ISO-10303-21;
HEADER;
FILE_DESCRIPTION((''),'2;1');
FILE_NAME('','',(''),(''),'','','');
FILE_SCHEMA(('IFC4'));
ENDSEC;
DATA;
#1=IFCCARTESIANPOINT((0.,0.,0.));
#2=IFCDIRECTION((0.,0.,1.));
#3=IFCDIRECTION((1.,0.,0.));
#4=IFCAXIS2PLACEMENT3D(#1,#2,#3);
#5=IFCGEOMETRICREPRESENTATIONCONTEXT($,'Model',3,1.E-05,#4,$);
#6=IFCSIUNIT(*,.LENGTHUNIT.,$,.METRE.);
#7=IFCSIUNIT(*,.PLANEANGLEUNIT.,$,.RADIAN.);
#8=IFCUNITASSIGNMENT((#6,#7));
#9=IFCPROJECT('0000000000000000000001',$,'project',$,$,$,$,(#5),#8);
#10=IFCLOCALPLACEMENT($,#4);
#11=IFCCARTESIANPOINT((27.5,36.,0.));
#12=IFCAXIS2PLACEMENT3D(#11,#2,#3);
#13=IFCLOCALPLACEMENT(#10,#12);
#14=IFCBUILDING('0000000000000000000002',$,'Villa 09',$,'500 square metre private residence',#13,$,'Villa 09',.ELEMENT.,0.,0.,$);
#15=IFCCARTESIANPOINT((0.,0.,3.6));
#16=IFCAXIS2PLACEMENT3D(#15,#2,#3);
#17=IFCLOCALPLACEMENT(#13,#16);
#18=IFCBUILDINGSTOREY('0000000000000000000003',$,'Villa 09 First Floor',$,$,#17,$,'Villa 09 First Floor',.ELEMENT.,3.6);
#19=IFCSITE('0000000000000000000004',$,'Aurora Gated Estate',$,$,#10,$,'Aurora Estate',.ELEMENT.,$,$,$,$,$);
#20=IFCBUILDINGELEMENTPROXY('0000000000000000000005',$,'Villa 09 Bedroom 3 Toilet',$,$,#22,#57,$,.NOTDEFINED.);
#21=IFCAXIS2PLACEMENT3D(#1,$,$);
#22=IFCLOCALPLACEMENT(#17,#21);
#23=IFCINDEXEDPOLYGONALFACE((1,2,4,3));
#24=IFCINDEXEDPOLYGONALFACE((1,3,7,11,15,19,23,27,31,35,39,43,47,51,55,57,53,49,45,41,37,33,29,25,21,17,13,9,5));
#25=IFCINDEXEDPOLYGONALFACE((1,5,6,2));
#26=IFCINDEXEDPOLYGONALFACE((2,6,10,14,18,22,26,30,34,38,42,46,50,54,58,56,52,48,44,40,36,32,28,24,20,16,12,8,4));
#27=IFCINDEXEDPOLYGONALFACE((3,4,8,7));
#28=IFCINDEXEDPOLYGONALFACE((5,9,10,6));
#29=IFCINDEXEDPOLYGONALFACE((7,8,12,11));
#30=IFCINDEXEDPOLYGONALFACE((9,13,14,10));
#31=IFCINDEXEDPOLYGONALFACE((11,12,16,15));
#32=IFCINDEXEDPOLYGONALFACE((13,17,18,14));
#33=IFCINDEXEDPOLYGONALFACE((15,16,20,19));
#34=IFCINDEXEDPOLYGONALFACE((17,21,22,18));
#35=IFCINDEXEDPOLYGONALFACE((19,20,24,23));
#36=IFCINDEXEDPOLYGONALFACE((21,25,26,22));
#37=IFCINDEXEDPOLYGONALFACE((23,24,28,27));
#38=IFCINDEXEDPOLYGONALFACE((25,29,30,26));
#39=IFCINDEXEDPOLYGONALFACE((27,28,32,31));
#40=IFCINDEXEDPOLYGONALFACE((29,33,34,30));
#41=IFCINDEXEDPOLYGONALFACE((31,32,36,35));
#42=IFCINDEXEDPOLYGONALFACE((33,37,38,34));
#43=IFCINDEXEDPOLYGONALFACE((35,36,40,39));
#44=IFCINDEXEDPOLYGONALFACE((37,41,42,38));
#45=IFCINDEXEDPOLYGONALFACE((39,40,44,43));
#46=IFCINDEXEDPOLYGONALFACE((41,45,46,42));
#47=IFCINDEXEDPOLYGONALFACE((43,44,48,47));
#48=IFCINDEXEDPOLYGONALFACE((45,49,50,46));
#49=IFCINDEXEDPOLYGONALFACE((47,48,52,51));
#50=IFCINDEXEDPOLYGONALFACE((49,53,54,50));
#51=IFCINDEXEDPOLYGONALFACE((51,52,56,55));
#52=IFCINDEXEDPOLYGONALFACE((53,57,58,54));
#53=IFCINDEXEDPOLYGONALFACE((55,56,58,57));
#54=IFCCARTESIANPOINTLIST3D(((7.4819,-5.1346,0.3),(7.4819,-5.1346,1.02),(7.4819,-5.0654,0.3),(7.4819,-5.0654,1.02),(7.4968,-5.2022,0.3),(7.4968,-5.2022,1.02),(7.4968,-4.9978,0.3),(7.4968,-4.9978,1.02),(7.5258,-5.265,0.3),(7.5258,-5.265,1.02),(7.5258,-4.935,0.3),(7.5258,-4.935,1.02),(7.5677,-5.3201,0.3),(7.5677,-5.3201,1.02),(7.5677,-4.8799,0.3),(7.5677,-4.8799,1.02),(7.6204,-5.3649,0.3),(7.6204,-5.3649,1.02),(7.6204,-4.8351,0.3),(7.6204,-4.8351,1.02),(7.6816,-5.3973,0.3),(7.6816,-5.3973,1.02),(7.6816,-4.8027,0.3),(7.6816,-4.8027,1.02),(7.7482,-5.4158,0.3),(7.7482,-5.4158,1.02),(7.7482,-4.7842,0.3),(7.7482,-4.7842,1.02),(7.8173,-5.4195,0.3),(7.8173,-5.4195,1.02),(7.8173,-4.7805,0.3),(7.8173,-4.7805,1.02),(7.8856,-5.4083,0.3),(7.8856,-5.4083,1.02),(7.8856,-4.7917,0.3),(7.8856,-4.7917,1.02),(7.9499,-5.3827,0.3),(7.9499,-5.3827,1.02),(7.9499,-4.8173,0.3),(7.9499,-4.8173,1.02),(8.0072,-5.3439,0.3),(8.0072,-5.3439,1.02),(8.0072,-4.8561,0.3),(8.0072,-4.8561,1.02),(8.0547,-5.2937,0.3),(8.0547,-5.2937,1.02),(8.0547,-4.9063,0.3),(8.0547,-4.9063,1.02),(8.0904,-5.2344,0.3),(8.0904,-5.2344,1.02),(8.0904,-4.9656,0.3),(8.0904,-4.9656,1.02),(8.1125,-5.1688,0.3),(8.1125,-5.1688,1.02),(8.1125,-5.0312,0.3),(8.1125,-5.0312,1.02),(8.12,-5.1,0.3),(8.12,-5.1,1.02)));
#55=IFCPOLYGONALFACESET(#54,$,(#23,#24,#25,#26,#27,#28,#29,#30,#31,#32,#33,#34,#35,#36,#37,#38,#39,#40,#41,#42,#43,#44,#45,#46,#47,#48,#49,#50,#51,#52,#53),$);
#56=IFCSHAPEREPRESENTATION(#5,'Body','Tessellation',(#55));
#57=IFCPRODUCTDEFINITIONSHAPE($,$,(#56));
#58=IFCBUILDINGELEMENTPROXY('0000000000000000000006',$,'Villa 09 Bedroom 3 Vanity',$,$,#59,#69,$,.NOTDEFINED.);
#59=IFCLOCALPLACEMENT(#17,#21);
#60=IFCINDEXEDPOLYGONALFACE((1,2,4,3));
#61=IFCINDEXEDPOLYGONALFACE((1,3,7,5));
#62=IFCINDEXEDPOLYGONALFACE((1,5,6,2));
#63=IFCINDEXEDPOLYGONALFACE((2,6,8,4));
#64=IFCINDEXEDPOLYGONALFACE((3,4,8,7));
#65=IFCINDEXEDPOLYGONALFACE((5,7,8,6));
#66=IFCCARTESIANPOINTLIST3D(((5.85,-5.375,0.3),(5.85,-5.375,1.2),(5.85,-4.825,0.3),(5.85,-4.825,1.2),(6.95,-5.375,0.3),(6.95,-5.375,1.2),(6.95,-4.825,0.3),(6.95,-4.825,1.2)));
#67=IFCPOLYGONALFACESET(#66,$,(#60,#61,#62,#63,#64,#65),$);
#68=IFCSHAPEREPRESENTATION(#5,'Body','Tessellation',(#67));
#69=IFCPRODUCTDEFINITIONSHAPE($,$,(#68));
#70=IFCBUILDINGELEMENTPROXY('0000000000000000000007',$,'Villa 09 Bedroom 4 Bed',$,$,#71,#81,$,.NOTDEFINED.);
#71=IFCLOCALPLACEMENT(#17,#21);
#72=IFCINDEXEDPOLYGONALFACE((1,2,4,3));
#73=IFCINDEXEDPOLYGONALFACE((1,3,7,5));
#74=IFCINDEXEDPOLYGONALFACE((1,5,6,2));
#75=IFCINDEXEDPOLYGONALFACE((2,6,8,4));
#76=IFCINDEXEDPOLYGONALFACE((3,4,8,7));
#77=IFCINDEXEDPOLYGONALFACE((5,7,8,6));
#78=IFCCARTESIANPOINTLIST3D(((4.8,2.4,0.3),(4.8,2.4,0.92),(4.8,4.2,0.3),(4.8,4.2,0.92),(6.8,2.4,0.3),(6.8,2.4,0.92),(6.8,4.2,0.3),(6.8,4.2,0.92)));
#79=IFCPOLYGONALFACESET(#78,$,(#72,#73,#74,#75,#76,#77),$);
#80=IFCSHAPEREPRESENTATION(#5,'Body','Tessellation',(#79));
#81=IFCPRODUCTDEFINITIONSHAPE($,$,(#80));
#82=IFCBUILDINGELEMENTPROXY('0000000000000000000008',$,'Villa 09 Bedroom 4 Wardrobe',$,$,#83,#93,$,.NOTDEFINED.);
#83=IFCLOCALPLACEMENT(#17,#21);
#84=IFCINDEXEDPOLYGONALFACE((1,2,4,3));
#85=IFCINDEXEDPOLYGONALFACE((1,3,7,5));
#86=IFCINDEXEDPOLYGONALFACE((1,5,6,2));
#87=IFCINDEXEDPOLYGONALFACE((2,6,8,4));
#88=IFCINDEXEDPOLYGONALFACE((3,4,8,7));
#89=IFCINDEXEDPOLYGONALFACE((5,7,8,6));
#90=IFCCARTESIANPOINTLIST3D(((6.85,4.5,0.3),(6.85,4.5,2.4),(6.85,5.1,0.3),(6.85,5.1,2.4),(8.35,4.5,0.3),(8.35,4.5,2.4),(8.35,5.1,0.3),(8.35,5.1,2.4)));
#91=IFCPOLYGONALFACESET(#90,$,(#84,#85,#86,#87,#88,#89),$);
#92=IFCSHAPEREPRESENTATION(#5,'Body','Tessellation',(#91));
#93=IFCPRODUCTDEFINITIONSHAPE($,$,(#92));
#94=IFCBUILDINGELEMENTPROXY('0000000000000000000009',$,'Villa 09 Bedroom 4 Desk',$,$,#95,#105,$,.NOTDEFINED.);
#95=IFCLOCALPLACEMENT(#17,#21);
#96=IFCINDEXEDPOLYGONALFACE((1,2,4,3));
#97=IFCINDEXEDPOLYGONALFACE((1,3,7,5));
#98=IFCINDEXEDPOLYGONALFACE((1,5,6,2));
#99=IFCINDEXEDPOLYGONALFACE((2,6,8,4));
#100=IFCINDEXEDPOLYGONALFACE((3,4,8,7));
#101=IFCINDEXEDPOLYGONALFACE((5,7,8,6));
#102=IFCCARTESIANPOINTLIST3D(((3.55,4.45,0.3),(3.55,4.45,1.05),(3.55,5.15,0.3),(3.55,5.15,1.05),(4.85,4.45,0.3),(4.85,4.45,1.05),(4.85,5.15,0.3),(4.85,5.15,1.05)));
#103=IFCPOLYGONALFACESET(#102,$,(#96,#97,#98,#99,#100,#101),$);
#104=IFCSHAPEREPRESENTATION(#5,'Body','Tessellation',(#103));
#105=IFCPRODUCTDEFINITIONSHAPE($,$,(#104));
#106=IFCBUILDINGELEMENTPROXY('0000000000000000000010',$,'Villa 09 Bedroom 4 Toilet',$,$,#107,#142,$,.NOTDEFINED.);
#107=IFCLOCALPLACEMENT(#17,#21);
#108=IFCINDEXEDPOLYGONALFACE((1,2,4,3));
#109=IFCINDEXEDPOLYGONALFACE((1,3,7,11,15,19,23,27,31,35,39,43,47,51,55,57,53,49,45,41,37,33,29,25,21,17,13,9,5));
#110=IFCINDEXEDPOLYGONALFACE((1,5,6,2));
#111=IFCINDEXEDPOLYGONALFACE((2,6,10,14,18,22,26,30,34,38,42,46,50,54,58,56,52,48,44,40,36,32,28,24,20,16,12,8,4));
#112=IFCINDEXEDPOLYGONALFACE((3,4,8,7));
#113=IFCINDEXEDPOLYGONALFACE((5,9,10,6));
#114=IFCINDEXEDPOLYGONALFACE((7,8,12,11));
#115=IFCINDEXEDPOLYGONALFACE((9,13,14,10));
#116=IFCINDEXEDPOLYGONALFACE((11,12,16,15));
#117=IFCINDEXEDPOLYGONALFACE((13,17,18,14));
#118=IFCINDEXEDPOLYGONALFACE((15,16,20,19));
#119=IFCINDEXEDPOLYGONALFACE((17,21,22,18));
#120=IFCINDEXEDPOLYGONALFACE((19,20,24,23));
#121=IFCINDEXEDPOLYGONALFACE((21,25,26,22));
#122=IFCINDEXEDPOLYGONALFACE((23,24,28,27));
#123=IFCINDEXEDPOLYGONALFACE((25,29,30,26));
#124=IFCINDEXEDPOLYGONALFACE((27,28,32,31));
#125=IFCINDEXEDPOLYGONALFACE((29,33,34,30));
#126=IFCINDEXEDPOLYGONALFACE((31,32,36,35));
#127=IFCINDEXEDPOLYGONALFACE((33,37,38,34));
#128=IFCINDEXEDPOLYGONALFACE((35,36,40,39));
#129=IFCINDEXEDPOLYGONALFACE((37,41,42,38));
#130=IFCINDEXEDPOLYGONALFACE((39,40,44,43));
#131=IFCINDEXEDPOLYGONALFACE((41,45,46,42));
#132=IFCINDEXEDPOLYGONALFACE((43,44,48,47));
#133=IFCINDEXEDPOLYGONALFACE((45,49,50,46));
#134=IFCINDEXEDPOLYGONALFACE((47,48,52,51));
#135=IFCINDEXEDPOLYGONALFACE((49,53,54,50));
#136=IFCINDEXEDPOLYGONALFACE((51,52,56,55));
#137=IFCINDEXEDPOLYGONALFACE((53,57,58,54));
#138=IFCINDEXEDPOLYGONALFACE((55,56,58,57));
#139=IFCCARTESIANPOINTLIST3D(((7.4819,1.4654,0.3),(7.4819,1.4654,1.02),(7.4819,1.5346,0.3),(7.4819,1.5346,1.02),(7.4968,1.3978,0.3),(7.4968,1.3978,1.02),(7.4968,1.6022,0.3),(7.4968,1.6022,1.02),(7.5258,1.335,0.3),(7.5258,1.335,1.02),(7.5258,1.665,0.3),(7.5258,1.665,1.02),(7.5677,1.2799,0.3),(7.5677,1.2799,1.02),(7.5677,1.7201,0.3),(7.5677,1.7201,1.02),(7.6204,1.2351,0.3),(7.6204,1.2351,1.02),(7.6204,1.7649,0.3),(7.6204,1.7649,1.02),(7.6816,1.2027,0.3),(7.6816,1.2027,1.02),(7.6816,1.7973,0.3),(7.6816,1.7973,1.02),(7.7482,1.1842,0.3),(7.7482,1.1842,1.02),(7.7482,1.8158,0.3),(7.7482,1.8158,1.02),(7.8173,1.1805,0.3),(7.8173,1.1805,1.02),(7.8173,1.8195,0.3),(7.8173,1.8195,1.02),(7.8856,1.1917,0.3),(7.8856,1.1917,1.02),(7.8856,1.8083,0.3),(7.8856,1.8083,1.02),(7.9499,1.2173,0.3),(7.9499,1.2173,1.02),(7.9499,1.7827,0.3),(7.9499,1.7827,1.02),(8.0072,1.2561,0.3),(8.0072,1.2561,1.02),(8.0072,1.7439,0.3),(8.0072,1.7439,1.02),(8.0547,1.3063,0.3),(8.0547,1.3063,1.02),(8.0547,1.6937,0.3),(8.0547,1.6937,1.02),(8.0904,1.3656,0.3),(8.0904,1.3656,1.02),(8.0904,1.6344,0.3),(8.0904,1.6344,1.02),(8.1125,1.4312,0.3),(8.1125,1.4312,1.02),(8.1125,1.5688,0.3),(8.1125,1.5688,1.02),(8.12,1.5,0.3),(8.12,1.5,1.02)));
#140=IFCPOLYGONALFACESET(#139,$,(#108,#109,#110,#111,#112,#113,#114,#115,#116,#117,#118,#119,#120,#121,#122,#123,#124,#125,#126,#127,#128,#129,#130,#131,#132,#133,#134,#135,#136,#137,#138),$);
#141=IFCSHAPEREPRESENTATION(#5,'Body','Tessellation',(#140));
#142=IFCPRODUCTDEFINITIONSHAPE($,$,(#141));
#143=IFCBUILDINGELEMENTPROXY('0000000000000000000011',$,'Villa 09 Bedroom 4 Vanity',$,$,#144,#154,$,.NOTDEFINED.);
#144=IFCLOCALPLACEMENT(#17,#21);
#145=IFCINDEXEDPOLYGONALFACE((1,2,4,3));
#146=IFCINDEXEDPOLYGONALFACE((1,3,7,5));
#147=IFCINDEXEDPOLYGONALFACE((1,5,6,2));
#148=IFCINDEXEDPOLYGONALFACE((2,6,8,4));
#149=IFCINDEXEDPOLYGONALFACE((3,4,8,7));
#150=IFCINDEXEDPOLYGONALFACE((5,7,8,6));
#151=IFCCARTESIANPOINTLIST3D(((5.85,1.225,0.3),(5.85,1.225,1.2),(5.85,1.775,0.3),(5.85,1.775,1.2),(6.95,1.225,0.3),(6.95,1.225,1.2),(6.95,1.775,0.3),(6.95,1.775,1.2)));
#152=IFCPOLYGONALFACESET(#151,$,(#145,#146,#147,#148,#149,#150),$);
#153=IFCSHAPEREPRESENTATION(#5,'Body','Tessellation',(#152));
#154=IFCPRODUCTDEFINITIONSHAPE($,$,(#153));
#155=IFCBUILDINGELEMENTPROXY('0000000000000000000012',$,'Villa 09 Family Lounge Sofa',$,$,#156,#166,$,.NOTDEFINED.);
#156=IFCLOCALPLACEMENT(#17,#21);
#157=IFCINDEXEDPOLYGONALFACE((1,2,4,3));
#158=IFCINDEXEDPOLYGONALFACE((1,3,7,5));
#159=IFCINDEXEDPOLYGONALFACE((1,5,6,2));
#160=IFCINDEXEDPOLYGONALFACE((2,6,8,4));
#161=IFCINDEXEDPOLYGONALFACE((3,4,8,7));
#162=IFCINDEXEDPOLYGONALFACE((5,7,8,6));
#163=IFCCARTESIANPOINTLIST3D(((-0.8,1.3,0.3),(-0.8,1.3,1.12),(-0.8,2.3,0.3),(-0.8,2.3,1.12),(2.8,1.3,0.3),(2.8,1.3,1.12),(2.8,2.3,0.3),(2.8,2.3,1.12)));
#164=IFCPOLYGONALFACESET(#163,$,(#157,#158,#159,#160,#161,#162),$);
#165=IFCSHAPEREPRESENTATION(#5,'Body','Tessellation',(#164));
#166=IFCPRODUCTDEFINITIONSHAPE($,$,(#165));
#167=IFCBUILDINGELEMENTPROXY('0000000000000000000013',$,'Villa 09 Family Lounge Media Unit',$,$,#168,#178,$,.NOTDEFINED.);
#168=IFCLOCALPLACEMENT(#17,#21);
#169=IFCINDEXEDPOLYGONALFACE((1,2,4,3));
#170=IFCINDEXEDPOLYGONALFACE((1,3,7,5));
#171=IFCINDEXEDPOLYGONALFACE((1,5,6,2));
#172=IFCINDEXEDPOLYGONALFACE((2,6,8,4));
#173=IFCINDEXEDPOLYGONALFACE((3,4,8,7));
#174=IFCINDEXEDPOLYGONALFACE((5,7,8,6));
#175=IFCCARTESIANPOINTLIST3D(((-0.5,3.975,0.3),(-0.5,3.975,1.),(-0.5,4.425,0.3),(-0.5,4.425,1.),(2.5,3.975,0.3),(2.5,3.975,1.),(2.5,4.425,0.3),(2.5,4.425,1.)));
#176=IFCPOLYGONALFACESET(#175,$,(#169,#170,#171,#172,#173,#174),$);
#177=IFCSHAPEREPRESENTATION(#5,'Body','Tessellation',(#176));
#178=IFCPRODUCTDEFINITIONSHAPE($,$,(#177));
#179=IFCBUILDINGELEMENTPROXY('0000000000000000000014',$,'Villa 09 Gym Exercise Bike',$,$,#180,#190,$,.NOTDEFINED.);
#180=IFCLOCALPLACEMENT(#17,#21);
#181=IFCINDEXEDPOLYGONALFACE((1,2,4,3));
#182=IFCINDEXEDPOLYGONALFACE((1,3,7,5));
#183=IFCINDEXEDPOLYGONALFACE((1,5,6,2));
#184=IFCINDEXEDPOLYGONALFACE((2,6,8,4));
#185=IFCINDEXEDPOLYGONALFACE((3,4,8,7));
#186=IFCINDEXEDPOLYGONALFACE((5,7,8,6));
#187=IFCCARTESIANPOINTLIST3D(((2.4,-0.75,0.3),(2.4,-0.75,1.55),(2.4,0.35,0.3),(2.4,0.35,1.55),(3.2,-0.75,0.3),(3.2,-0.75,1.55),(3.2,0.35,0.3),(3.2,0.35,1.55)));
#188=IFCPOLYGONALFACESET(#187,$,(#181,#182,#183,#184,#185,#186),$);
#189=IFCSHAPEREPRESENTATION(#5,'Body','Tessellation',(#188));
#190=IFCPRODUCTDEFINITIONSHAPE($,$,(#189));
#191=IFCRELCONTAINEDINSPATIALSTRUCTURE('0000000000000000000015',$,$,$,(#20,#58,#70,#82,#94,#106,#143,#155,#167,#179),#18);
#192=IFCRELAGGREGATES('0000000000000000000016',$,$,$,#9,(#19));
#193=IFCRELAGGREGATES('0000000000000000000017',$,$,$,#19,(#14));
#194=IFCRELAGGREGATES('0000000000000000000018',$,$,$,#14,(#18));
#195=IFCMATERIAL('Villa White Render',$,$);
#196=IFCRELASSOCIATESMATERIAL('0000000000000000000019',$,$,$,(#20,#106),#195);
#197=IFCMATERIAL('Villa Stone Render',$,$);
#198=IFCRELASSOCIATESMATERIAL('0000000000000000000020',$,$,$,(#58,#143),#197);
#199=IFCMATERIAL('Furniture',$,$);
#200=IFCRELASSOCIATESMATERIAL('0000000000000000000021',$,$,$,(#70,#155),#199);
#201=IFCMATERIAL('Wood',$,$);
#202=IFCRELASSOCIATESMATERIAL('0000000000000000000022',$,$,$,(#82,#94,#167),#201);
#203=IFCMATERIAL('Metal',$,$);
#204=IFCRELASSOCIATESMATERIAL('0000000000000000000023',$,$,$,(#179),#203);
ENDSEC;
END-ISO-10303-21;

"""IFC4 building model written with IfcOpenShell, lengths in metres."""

from ifc_helpers import new_model, si_unit, frame, origin_with_axes, origin_2d_with_axis, place, context, project, spatial, rectangle, circle, extrude, material, element, save


model = new_model("IFC4")

# Units and contexts
model_context = context("Model", 3, precision=1e-05, world=origin_with_axes())
ifc_project = project(units=[si_unit("LENGTHUNIT", "METRE"), si_unit("PLANEANGLEUNIT", "RADIAN")], contexts=[model_context])

# Site, building, storey
site_placement = place(None, origin_with_axes())
site = spatial("IfcSite", under=ifc_project, at=site_placement, Name="Aurora Gated Estate", LongName="Aurora Estate", CompositionType="ELEMENT")
building_placement = place(site_placement, frame((27.5, 36.0, 0.0), z_axis=(0.0, 0.0, 1.0), x_axis=(1.0, 0.0, 0.0)))
building = spatial("IfcBuilding", under=site, at=building_placement, Name="Villa 09", ObjectType="500 square metre private residence", LongName="Villa 09", CompositionType="ELEMENT", ElevationOfRefHeight=0.0, ElevationOfTerrain=0.0)
storey_placement = place(building_placement, frame((0.0, 0.0, 3.6), z_axis=(0.0, 0.0, 1.0), x_axis=(1.0, 0.0, 0.0)))
storey = spatial("IfcBuildingStorey", under=building, at=storey_placement, Name="Villa 09 First Floor", LongName="Villa 09 First Floor", CompositionType="ELEMENT", Elevation=3.6)

# Shared definitions
ifc_material_1 = material(Name="Villa Stone Render")

# Building element proxies
ifc_material_2 = material(Name="Wood")
ifc_material_3 = material(Name="Villa White Render")
ifc_material_4 = material(Name="Furniture")
proxy_1_placement = place(storey_placement, frame((7.8, -5.1, 0.3), z_axis=(0.0, 0.0, 1.0), x_axis=(1.0, 0.0, 0.0)))
element("IfcBuildingElementProxy", 1, at=proxy_1_placement, inside=storey, material=ifc_material_3, Name="Villa 09 Bedroom 3 Toilet", PredefinedType="NOTDEFINED", context=model_context, shape_type="SweptSolid", body=[
    extrude(circle(Radius=0.32, at=origin_2d_with_axis()), origin_with_axes(), (0.0, 0.0, 1.0), 0.72),
])
proxy_2_placement = place(storey_placement, frame((6.4, -5.1, 0.3), z_axis=(0.0, 0.0, 1.0), x_axis=(1.0, 0.0, 0.0)))
element("IfcBuildingElementProxy", 2, at=proxy_2_placement, inside=storey, material=ifc_material_1, Name="Villa 09 Bedroom 3 Vanity", PredefinedType="NOTDEFINED", context=model_context, shape_type="SweptSolid", body=[
    extrude(rectangle(XDim=1.1, YDim=0.55, at=origin_2d_with_axis()), origin_with_axes(), (0.0, 0.0, 1.0), 0.9),
])
proxy_3_placement = place(storey_placement, frame((5.8, 3.3, 0.3), z_axis=(0.0, 0.0, 1.0), x_axis=(1.0, 0.0, 0.0)))
element("IfcBuildingElementProxy", 3, at=proxy_3_placement, inside=storey, material=ifc_material_4, Name="Villa 09 Bedroom 4 Bed", PredefinedType="NOTDEFINED", context=model_context, shape_type="SweptSolid", body=[
    extrude(rectangle(XDim=2.0, YDim=1.8, at=origin_2d_with_axis()), origin_with_axes(), (0.0, 0.0, 1.0), 0.62),
])
proxy_4_placement = place(storey_placement, frame((7.6, 4.8, 0.3), z_axis=(0.0, 0.0, 1.0), x_axis=(1.0, 0.0, 0.0)))
element("IfcBuildingElementProxy", 4, at=proxy_4_placement, inside=storey, material=ifc_material_2, Name="Villa 09 Bedroom 4 Wardrobe", PredefinedType="NOTDEFINED", context=model_context, shape_type="SweptSolid", body=[
    extrude(rectangle(XDim=1.5, YDim=0.6, at=origin_2d_with_axis()), origin_with_axes(), (0.0, 0.0, 1.0), 2.1),
])
proxy_5_placement = place(storey_placement, frame((4.2, 4.8, 0.3), z_axis=(0.0, 0.0, 1.0), x_axis=(1.0, 0.0, 0.0)))
element("IfcBuildingElementProxy", 5, at=proxy_5_placement, inside=storey, material=ifc_material_2, Name="Villa 09 Bedroom 4 Desk", PredefinedType="NOTDEFINED", context=model_context, shape_type="SweptSolid", body=[
    extrude(rectangle(XDim=1.3, YDim=0.7, at=origin_2d_with_axis()), origin_with_axes(), (0.0, 0.0, 1.0), 0.75),
])
proxy_6_placement = place(storey_placement, frame((7.8, 1.5, 0.3), z_axis=(0.0, 0.0, 1.0), x_axis=(1.0, 0.0, 0.0)))
element("IfcBuildingElementProxy", 6, at=proxy_6_placement, inside=storey, material=ifc_material_3, Name="Villa 09 Bedroom 4 Toilet", PredefinedType="NOTDEFINED", context=model_context, shape_type="SweptSolid", body=[
    extrude(circle(Radius=0.32, at=origin_2d_with_axis()), origin_with_axes(), (0.0, 0.0, 1.0), 0.72),
])
proxy_7_placement = place(storey_placement, frame((6.4, 1.5, 0.3), z_axis=(0.0, 0.0, 1.0), x_axis=(1.0, 0.0, 0.0)))
element("IfcBuildingElementProxy", 7, at=proxy_7_placement, inside=storey, material=ifc_material_1, Name="Villa 09 Bedroom 4 Vanity", PredefinedType="NOTDEFINED", context=model_context, shape_type="SweptSolid", body=[
    extrude(rectangle(XDim=1.1, YDim=0.55, at=origin_2d_with_axis()), origin_with_axes(), (0.0, 0.0, 1.0), 0.9),
])
proxy_8_placement = place(storey_placement, frame((1.0, 1.8, 0.3), z_axis=(0.0, 0.0, 1.0), x_axis=(1.0, 0.0, 0.0)))
element("IfcBuildingElementProxy", 8, at=proxy_8_placement, inside=storey, material=ifc_material_4, Name="Villa 09 Family Lounge Sofa", PredefinedType="NOTDEFINED", context=model_context, shape_type="SweptSolid", body=[
    extrude(rectangle(XDim=3.6, YDim=1.0, at=origin_2d_with_axis()), origin_with_axes(), (0.0, 0.0, 1.0), 0.82),
])
proxy_9_placement = place(storey_placement, frame((1.0, 4.2, 0.3), z_axis=(0.0, 0.0, 1.0), x_axis=(1.0, 0.0, 0.0)))
element("IfcBuildingElementProxy", 9, at=proxy_9_placement, inside=storey, material=ifc_material_2, Name="Villa 09 Family Lounge Media Unit", PredefinedType="NOTDEFINED", context=model_context, shape_type="SweptSolid", body=[
    extrude(rectangle(XDim=3.0, YDim=0.45, at=origin_2d_with_axis()), origin_with_axes(), (0.0, 0.0, 1.0), 0.7),
])
ifc_material_5 = material(Name="Metal")
proxy_10_placement = place(storey_placement, frame((2.8, -0.2, 0.3), z_axis=(0.0, 0.0, 1.0), x_axis=(1.0, 0.0, 0.0)))
element("IfcBuildingElementProxy", 10, at=proxy_10_placement, inside=storey, material=ifc_material_5, Name="Villa 09 Gym Exercise Bike", PredefinedType="NOTDEFINED", context=model_context, shape_type="SweptSolid", body=[
    extrude(rectangle(XDim=0.8, YDim=1.1, at=origin_2d_with_axis()), origin_with_axes(), (0.0, 0.0, 1.0), 1.25),
])

save(model, "model.ifc")
